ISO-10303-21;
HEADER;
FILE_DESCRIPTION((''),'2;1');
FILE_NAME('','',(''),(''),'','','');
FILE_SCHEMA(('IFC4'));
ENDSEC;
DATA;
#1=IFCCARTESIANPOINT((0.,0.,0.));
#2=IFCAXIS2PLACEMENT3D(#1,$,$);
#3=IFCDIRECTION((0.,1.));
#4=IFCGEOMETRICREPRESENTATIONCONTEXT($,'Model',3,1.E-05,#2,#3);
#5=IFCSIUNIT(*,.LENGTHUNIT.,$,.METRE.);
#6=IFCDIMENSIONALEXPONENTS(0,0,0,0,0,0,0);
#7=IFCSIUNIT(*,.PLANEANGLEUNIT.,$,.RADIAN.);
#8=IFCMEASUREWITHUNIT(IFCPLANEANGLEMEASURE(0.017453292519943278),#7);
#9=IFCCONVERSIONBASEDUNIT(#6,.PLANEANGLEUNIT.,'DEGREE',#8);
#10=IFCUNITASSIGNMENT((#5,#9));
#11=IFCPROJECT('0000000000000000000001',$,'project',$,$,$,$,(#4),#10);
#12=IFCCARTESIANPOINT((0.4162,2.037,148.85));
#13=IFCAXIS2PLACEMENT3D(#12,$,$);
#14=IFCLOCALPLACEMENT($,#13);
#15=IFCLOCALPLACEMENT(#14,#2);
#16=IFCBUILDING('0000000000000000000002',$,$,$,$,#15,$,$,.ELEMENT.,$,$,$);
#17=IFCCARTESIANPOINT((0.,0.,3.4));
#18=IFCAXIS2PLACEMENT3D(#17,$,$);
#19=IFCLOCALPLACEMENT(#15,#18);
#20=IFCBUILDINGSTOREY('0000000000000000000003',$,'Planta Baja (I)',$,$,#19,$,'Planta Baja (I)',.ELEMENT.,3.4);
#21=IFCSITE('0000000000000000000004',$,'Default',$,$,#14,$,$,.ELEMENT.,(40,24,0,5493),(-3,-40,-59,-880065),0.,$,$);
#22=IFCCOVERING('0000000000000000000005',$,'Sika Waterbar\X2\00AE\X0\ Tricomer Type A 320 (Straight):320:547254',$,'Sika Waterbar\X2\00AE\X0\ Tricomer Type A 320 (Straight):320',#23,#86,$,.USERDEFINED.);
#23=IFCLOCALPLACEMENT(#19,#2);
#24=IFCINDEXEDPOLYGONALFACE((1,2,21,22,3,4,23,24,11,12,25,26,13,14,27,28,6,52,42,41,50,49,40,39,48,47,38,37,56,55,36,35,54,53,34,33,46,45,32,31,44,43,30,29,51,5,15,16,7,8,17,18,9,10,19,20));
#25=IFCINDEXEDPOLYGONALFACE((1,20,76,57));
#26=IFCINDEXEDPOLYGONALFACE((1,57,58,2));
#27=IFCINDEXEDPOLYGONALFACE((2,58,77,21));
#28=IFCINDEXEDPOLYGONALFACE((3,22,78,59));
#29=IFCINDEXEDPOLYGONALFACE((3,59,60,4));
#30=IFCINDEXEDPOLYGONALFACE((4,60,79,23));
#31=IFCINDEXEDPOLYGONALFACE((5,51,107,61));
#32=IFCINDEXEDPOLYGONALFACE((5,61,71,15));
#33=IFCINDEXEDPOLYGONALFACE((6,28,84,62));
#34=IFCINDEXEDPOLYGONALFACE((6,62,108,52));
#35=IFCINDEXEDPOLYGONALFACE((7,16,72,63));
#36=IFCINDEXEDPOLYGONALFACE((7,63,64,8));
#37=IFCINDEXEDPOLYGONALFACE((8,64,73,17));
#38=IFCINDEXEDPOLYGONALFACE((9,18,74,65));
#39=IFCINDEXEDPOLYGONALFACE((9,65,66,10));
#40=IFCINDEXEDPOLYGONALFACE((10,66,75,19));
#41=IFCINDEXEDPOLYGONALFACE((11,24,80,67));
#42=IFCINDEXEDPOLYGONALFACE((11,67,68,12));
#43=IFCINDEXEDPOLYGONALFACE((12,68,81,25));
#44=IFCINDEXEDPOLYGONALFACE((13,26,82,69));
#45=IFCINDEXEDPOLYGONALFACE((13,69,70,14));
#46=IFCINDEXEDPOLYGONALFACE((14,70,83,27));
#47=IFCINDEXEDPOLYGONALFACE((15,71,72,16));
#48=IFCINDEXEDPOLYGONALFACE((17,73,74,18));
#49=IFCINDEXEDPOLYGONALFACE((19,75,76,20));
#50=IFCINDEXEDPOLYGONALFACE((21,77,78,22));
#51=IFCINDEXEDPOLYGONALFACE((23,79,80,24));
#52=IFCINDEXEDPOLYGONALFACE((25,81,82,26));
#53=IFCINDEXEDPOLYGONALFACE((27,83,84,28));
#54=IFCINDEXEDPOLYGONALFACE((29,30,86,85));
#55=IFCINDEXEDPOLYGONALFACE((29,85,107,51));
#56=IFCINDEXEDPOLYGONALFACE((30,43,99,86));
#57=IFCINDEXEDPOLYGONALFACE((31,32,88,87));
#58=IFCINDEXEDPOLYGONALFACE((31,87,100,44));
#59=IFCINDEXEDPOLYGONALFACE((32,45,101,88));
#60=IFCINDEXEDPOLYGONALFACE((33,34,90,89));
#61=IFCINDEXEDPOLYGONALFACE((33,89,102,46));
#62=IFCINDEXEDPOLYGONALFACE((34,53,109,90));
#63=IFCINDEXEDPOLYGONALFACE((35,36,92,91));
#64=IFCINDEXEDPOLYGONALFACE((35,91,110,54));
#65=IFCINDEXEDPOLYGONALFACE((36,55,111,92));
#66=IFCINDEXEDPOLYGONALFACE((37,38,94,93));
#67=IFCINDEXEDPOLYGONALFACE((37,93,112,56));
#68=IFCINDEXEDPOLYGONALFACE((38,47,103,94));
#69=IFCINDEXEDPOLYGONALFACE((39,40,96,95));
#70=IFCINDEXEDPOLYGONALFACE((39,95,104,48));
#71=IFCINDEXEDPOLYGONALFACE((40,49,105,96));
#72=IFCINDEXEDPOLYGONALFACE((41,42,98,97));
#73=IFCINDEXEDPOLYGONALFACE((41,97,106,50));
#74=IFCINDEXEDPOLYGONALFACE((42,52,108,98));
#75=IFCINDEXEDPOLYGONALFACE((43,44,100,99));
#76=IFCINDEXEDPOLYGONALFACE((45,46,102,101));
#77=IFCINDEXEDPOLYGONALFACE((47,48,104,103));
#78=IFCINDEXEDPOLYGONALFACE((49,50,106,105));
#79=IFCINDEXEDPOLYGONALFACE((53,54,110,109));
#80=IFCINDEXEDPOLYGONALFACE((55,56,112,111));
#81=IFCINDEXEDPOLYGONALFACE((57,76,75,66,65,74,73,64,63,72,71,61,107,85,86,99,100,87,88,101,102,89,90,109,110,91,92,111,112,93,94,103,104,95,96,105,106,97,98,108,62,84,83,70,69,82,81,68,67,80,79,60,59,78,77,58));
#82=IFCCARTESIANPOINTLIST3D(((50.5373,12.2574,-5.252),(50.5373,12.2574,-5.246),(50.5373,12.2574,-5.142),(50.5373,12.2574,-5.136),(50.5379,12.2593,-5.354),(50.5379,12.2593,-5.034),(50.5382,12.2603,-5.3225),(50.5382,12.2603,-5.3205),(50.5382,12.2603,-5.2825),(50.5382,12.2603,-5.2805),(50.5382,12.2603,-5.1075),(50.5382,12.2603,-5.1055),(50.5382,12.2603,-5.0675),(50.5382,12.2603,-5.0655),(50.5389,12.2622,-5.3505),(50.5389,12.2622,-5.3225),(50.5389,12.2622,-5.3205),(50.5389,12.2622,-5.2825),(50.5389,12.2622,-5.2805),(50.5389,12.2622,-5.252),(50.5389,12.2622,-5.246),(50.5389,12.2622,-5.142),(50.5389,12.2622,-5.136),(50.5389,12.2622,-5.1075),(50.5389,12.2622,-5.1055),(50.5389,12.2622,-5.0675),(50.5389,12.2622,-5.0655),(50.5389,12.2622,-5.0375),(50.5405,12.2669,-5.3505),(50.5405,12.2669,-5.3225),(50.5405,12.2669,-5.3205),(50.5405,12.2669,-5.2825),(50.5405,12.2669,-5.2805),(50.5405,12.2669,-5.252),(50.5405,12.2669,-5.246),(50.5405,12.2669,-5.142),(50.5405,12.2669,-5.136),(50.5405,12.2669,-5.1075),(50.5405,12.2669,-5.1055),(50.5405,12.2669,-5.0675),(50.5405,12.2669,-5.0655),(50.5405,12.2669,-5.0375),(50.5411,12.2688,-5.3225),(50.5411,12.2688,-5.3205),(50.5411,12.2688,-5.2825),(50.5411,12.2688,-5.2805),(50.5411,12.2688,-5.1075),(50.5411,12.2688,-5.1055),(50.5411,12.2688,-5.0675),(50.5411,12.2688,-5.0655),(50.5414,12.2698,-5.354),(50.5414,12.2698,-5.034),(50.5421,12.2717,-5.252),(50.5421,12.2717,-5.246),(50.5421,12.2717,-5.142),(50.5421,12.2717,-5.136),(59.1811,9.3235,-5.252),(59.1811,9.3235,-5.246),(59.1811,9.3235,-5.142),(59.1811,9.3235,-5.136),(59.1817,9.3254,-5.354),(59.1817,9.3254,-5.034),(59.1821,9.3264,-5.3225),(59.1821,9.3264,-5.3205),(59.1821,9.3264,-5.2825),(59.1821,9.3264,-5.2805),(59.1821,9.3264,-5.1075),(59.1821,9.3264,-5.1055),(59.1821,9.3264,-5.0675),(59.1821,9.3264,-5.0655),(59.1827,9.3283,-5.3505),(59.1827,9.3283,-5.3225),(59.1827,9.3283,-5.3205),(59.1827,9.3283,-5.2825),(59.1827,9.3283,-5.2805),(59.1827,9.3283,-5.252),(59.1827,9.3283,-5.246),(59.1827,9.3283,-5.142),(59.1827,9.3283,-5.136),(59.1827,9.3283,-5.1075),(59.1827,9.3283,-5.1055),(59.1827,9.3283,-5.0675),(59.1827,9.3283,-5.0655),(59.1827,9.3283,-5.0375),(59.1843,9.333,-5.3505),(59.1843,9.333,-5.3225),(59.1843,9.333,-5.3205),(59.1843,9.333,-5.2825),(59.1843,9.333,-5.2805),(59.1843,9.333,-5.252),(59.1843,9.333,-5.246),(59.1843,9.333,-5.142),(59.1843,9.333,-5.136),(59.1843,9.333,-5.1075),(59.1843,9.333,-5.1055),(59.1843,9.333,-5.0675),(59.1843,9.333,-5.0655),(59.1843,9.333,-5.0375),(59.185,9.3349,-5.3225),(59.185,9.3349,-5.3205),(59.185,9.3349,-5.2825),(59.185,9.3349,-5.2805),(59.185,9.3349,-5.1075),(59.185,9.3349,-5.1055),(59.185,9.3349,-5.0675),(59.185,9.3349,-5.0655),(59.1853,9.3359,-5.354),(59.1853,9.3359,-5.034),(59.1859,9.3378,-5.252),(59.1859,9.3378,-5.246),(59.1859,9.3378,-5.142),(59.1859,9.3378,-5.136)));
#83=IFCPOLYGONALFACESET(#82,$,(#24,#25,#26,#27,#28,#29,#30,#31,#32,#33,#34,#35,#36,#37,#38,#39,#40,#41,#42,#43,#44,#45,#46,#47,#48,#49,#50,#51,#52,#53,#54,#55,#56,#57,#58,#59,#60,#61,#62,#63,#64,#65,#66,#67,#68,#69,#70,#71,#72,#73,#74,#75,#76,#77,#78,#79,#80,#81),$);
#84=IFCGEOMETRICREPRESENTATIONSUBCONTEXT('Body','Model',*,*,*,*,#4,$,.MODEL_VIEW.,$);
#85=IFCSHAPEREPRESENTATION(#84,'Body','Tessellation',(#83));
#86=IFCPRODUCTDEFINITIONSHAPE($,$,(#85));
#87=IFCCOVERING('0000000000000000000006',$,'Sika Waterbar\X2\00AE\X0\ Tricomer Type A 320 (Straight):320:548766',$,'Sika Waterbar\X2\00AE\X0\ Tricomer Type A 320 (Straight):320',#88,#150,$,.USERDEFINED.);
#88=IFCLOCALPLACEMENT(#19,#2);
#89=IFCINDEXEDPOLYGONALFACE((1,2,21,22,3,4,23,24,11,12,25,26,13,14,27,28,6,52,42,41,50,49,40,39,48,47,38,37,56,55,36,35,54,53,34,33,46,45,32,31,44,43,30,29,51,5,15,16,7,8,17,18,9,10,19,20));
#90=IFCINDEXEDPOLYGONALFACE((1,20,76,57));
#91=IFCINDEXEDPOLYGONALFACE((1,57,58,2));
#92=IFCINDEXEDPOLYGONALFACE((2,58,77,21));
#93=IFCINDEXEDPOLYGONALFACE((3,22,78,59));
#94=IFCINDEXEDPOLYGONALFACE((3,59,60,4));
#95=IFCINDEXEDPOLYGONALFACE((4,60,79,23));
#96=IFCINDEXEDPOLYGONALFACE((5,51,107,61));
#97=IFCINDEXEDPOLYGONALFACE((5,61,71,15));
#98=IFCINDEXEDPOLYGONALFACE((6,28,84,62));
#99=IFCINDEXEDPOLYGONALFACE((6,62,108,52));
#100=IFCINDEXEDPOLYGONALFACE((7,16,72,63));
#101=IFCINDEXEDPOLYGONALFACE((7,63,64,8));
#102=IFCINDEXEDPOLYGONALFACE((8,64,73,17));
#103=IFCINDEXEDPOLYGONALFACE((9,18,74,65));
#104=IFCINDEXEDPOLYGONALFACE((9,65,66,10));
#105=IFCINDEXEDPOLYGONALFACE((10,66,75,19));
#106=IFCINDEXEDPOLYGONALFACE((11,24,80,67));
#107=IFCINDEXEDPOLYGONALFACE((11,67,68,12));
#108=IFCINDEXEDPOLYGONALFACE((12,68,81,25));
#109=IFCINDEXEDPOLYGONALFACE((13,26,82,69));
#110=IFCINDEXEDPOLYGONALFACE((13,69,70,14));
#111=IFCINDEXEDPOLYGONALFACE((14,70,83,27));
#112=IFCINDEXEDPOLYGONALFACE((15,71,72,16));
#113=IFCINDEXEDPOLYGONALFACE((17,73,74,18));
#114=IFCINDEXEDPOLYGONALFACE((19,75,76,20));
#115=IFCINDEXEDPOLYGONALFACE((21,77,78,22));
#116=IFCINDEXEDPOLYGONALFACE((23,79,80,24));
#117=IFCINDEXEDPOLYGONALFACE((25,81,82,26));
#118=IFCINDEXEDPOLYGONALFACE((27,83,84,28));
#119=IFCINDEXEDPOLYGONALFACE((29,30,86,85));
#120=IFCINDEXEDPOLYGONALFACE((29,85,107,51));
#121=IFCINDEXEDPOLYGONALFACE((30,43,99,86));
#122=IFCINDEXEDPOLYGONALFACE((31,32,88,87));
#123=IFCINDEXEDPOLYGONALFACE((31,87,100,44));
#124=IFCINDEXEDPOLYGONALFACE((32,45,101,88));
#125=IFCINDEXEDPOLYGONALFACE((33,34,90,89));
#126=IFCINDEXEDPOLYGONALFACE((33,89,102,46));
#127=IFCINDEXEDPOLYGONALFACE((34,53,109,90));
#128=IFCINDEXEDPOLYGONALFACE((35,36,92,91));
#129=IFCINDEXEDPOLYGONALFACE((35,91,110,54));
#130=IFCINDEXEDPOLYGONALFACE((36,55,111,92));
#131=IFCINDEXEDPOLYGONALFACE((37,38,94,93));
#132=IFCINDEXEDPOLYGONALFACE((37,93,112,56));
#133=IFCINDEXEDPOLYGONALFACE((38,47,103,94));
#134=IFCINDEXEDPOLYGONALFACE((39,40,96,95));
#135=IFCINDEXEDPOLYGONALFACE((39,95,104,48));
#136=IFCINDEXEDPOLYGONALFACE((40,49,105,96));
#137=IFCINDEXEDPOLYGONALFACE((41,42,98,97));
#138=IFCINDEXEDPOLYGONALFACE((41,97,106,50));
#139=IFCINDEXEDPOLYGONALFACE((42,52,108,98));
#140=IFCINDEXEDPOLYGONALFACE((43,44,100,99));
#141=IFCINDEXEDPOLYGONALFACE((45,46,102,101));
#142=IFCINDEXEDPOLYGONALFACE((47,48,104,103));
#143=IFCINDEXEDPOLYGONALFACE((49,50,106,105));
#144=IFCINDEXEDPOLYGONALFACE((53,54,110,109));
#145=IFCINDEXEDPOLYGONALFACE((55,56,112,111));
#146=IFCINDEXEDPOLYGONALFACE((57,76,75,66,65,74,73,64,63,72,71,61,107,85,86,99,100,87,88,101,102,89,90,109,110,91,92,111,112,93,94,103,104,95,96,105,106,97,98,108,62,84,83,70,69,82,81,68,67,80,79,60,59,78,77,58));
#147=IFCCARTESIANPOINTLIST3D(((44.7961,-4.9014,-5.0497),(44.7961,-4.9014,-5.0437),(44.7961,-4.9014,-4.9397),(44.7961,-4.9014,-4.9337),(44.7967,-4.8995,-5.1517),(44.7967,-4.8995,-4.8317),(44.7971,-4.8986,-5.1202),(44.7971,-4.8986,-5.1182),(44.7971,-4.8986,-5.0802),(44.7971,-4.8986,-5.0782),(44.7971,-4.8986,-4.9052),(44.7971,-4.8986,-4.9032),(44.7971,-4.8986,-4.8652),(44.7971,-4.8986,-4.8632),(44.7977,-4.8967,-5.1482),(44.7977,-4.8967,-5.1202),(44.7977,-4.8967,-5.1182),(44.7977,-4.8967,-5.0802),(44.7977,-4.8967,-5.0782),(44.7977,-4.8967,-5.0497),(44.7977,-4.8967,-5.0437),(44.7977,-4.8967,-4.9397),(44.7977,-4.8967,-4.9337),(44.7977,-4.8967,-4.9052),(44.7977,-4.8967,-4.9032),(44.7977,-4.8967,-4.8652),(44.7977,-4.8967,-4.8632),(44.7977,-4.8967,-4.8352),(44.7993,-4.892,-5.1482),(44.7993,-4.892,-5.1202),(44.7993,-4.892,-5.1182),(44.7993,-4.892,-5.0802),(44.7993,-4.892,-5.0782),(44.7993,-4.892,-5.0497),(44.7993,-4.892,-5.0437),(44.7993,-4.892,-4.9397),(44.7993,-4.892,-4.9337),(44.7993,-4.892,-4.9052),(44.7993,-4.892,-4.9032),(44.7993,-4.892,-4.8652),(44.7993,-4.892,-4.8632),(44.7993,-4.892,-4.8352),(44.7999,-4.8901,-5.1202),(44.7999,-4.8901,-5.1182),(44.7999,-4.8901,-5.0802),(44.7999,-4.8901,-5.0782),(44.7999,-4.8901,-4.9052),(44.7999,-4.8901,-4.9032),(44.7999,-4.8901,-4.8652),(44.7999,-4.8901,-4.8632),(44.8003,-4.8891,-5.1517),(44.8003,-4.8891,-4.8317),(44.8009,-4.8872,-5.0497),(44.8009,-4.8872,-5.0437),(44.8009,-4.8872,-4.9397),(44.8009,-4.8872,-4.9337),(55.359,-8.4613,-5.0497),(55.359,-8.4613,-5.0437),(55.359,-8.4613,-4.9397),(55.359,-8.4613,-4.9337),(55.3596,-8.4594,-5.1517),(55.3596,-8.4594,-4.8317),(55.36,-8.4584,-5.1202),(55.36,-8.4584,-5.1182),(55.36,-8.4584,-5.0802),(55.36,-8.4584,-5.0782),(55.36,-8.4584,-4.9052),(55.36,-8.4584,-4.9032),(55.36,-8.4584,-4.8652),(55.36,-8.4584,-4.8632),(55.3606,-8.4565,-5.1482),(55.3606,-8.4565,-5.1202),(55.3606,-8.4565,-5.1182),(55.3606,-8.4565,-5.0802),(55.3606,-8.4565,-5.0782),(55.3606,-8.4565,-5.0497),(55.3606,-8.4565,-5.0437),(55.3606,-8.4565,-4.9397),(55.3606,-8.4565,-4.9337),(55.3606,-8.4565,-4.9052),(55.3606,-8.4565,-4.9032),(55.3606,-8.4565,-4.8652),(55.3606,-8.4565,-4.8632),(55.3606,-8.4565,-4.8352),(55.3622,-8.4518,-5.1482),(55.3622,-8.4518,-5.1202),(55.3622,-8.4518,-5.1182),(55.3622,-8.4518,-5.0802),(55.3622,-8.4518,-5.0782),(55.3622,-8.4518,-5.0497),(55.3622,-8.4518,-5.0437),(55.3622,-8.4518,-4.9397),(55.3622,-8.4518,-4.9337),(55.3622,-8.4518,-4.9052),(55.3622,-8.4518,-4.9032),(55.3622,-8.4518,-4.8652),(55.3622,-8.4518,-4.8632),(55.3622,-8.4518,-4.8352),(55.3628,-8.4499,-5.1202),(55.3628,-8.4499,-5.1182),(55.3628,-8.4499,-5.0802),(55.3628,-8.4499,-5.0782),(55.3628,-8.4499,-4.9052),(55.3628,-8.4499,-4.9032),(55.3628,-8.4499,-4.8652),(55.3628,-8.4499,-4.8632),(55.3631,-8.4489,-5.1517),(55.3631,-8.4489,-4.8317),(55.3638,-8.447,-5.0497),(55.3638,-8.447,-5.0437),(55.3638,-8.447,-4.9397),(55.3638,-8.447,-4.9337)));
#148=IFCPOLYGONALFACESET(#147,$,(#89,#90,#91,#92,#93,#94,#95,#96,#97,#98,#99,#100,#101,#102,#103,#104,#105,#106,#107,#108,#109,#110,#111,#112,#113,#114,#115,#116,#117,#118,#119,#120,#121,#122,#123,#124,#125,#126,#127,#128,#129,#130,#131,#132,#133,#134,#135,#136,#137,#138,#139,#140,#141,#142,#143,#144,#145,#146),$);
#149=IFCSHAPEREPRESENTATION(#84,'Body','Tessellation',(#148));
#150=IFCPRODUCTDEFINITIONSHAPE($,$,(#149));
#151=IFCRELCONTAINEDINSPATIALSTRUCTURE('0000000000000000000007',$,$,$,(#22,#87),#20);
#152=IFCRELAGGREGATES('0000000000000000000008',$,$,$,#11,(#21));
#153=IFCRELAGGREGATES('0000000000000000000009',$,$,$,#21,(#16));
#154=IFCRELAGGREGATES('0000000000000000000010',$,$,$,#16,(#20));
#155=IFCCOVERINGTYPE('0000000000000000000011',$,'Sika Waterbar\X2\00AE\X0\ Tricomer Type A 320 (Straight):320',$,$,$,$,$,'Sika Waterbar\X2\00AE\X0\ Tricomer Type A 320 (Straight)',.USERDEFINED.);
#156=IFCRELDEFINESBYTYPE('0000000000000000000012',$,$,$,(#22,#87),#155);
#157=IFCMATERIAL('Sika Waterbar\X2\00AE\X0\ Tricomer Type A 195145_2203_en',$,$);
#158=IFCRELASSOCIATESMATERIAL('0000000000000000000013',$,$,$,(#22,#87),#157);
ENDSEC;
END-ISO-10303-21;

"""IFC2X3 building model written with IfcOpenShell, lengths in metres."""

from ifc_helpers import new_model, entity, si_unit, converted_unit, direction, frame, origin, place, context, subcontext, project, spatial, polyline, outline, extrude, material, type_object, element, save


model = new_model("IFC2X3")

# Units and contexts
model_context = context("Model", 3, precision=1e-05, world=origin(), true_north=direction((0.0, 1.0)))
body_context = subcontext(model_context, "Body", "Model", "MODEL_VIEW")
ifc_project = project(units=[si_unit("LENGTHUNIT", "METRE"), converted_unit("PLANEANGLEUNIT", "DEGREE", entity("IfcPlaneAngleMeasure", 0.017453292519943278), si_unit("PLANEANGLEUNIT", "RADIAN"), dimensions=[0, 0, 0, 0, 0, 0, 0])], contexts=[model_context])

# Site, building, storey
site_placement = place(None, frame((0.4162, 2.037, 148.85)))
site = spatial("IfcSite", under=ifc_project, at=site_placement, Name="Default", CompositionType="ELEMENT", RefLatitude=(40, 24, 0, 5493), RefLongitude=(-3, -40, -59, -880065), RefElevation=0.0)
building_placement = place(site_placement, origin())
building = spatial("IfcBuilding", under=site, at=building_placement, CompositionType="ELEMENT")
storey_placement = place(building_placement, frame((0.0, 0.0, 3.4)))
storey = spatial("IfcBuildingStorey", under=building, at=storey_placement, Name="Planta Baja (I)", LongName="Planta Baja (I)", CompositionType="ELEMENT", Elevation=3.4)

# Coverings
ifc_material_1 = material(Name="Sika Waterbar® Tricomer Type A 195145_2203_en")
covering_type = type_object("IfcCoveringType", Name="Sika Waterbar® Tricomer Type A 320 (Straight):320", ElementType="Sika Waterbar® Tricomer Type A 320 (Straight)", PredefinedType="USERDEFINED")
covering_1_placement = place(storey_placement, origin())
element("IfcCovering", 1, at=covering_1_placement, inside=storey, type_object=covering_type, material=ifc_material_1, Name="Sika Waterbar® Tricomer Type A 320 (Straight):320:547254", ObjectType="Sika Waterbar® Tricomer Type A 320 (Straight):320", PredefinedType="USERDEFINED", context=body_context, shape_type="SweptSolid", body=[
    extrude(outline(polyline([(0.052, -0.0075), (0.058, -0.0075), (0.058, -0.0025), (0.0865, -0.0025), (0.0865, -0.0045), (0.0885, -0.0045), (0.0885, -0.0025), (0.1265, -0.0025), (0.1265, -0.0045), (0.1285, -0.0045), (0.1285, -0.0025), (0.1565, -0.0025), (0.16, -0.0055), (0.16, 0.0055), (0.1565, 0.0025), (0.1285, 0.0025), (0.1285, 0.0045), (0.1265, 0.0045), (0.1265, 0.0025), (0.0885, 0.0025), (0.0885, 0.0045), (0.0865, 0.0045), (0.0865, 0.0025), (0.058, 0.0025), (0.058, 0.0075), (0.052, 0.0075), (0.052, 0.0025), (-0.052, 0.0025), (-0.052, 0.0075), (-0.058, 0.0075), (-0.058, 0.0025), (-0.0865, 0.0025), (-0.0865, 0.0045), (-0.0885, 0.0045), (-0.0885, 0.0025), (-0.1265, 0.0025), (-0.1265, 0.0045), (-0.1285, 0.0045), (-0.1285, 0.0025), (-0.1565, 0.0025), (-0.16, 0.0055), (-0.16, -0.0055), (-0.1565, -0.0025), (-0.1285, -0.0025), (-0.1285, -0.0045), (-0.1265, -0.0045), (-0.1265, -0.0025), (-0.0885, -0.0025), (-0.0885, -0.0045), (-0.0865, -0.0045), (-0.0865, -0.0025), (-0.058, -0.0025), (-0.058, -0.0075), (-0.052, -0.0075), (-0.052, -0.0025), (0.052, -0.0025), (0.052, -0.0075)])), frame((50.5397, 12.2645, -5.194), z_axis=(0.94694, -0.321411, 0.0), x_axis=(0.0, 0.0, -1.0)), (0.0, 0.0, 1.0), 9.1282),
])
covering_2_placement = place(storey_placement, origin())
element("IfcCovering", 2, at=covering_2_placement, inside=storey, type_object=covering_type, material=ifc_material_1, Name="Sika Waterbar® Tricomer Type A 320 (Straight):320:548766", ObjectType="Sika Waterbar® Tricomer Type A 320 (Straight):320", PredefinedType="USERDEFINED", context=body_context, shape_type="SweptSolid", body=[
    extrude(outline(polyline([(-0.0075, -0.052), (-0.0075, -0.058), (-0.0025, -0.058), (-0.0025, -0.0865), (-0.0045, -0.0865), (-0.0045, -0.0885), (-0.0025, -0.0885), (-0.0025, -0.1265), (-0.0045, -0.1265), (-0.0045, -0.1285), (-0.0025, -0.1285), (-0.0025, -0.1565), (-0.0055, -0.16), (0.0055, -0.16), (0.0025, -0.1565), (0.0025, -0.1285), (0.0045, -0.1285), (0.0045, -0.1265), (0.0025, -0.1265), (0.0025, -0.0885), (0.0045, -0.0885), (0.0045, -0.0865), (0.0025, -0.0865), (0.0025, -0.058), (0.0075, -0.058), (0.0075, -0.052), (0.0025, -0.052), (0.0025, 0.052), (0.0075, 0.052), (0.0075, 0.058), (0.0025, 0.058), (0.0025, 0.0865), (0.0045, 0.0865), (0.0045, 0.0885), (0.0025, 0.0885), (0.0025, 0.1265), (0.0045, 0.1265), (0.0045, 0.1285), (0.0025, 0.1285), (0.0025, 0.1565), (0.0055, 0.16), (-0.0055, 0.16), (-0.0025, 0.1565), (-0.0025, 0.1285), (-0.0045, 0.1285), (-0.0045, 0.1265), (-0.0025, 0.1265), (-0.0025, 0.0885), (-0.0045, 0.0885), (-0.0045, 0.0865), (-0.0025, 0.0865), (-0.0025, 0.058), (-0.0075, 0.058), (-0.0075, 0.052), (-0.0025, 0.052), (-0.0025, -0.052), (-0.0075, -0.052)])), frame((44.7985, -4.8943, -4.9917), z_axis=(-0.947632, 0.319364, 0.0), x_axis=(0.319364, 0.947632, 0.0)), (0.0, 0.0, -1.0), 11.1466),
])

save(model, "model.ifc")
